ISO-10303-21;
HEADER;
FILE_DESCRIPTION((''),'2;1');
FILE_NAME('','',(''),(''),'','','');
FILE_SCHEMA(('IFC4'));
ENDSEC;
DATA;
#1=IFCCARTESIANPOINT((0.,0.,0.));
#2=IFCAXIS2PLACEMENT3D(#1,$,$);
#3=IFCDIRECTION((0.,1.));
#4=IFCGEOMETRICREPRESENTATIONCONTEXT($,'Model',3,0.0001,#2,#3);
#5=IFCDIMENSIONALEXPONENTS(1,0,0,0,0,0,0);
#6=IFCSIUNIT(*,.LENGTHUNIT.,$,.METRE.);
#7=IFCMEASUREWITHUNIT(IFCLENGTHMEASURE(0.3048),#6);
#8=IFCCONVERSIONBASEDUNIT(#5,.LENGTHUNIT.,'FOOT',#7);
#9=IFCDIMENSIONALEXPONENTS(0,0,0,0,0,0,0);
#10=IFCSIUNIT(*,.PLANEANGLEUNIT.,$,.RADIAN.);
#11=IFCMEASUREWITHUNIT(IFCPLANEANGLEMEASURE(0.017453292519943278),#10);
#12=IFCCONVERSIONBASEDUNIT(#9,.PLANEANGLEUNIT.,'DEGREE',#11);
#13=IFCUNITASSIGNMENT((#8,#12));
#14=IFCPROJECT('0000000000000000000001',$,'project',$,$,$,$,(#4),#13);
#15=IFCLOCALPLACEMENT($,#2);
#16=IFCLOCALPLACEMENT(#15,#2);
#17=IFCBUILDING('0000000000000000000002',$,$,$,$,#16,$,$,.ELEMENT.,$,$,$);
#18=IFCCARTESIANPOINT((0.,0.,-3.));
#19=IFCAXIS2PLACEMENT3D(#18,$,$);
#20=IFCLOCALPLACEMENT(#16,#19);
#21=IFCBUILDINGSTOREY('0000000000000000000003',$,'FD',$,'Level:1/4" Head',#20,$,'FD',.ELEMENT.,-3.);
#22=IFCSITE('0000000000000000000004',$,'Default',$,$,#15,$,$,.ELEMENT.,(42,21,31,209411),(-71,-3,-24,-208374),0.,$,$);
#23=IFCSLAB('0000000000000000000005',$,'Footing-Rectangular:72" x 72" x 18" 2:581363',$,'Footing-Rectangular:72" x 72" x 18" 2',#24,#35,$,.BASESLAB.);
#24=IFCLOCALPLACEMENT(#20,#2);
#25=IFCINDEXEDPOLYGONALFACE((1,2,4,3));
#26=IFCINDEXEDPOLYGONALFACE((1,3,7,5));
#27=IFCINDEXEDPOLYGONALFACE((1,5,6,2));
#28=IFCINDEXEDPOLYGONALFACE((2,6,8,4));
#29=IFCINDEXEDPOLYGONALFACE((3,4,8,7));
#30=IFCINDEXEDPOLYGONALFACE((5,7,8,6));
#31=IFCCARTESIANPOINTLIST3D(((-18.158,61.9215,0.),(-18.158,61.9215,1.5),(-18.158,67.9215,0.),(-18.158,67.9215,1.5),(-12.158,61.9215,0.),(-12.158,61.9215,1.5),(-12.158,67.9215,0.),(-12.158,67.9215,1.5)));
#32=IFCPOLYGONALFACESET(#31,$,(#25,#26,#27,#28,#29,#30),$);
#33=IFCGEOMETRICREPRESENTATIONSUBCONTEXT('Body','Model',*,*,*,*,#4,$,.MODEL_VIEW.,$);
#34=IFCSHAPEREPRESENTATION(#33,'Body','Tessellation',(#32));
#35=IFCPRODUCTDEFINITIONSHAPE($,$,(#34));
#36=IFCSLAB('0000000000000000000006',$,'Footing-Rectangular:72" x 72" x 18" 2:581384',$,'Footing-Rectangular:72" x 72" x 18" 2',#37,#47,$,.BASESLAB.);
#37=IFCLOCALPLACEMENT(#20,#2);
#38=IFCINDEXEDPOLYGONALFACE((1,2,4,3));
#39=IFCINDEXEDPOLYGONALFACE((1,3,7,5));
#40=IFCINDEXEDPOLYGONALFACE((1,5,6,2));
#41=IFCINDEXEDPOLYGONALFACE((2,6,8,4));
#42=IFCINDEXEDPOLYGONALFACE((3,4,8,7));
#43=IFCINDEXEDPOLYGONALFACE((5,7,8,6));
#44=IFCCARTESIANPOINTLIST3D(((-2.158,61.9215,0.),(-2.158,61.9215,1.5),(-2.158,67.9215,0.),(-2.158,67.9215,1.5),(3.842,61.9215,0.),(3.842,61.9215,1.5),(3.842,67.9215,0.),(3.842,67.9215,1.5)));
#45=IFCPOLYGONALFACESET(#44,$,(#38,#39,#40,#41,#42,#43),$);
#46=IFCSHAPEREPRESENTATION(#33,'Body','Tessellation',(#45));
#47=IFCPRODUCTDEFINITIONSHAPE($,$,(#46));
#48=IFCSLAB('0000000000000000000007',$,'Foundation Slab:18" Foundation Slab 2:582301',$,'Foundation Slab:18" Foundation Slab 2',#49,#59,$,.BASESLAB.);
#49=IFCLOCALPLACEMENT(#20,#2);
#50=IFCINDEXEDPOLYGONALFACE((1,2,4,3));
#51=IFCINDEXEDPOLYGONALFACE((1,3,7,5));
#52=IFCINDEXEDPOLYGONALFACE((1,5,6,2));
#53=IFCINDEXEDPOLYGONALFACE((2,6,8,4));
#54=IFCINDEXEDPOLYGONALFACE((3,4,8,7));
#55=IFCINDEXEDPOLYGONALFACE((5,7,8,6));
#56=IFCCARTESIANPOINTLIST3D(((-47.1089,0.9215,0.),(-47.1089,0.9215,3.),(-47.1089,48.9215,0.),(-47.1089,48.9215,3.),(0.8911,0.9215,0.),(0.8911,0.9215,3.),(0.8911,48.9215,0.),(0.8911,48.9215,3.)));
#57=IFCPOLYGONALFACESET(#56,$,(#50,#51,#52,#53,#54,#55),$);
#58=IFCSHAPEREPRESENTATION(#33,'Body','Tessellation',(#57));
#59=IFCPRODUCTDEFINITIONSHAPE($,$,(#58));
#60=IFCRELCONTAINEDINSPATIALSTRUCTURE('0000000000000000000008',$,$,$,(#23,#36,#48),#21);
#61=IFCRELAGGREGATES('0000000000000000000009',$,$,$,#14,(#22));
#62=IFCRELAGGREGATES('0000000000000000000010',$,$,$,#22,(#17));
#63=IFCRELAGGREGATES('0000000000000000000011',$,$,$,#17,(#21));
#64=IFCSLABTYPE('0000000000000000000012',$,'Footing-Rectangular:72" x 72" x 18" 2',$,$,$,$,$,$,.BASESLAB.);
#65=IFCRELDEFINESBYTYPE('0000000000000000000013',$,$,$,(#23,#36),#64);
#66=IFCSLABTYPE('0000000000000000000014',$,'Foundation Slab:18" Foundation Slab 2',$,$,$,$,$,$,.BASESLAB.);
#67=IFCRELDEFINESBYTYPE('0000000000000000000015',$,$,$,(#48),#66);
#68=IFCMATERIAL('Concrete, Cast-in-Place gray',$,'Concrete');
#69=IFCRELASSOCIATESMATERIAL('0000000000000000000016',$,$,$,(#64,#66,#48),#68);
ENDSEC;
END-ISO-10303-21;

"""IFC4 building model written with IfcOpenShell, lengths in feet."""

from ifc_helpers import new_model, entity, si_unit, converted_unit, direction, frame, origin, place, context, subcontext, project, spatial, indexed_curve, outline, extrude, material, type_object, element, save


model = new_model("IFC4")

# Units and contexts
model_context = context("Model", 3, precision=0.0001, world=origin(), true_north=direction((0.0, 1.0)))
body_context = subcontext(model_context, "Body", "Model", "MODEL_VIEW")
ifc_project = project(units=[converted_unit("LENGTHUNIT", "FOOT", entity("IfcLengthMeasure", 0.3048), si_unit("LENGTHUNIT", "METRE"), dimensions=[1, 0, 0, 0, 0, 0, 0]), converted_unit("PLANEANGLEUNIT", "DEGREE", entity("IfcPlaneAngleMeasure", 0.017453292519943278), si_unit("PLANEANGLEUNIT", "RADIAN"), dimensions=[0, 0, 0, 0, 0, 0, 0])], contexts=[model_context])

# Site, building, storey
site_placement = place(None, origin())
site = spatial("IfcSite", under=ifc_project, at=site_placement, Name="Default", CompositionType="ELEMENT", RefLatitude=(42, 21, 31, 209411), RefLongitude=(-71, -3, -24, -208374), RefElevation=0.0)
building_placement = place(site_placement, origin())
building = spatial("IfcBuilding", under=site, at=building_placement, CompositionType="ELEMENT")
storey_placement = place(building_placement, frame((0.0, 0.0, -3.0)))
storey = spatial("IfcBuildingStorey", under=building, at=storey_placement, Name="FD", ObjectType="Level:1/4\" Head", LongName="FD", CompositionType="ELEMENT", Elevation=-3.0)

# Shared definitions
ifc_material = material(Name="Concrete, Cast-in-Place gray", Category="Concrete")

# Slabs
slab_type_1 = type_object("IfcSlabType", Name="Footing-Rectangular:72\" x 72\" x 18\" 2", PredefinedType="BASESLAB", material=ifc_material)
slab_1_placement = place(storey_placement, origin())
element("IfcSlab", 1, at=slab_1_placement, inside=storey, type_object=slab_type_1, Name="Footing-Rectangular:72\" x 72\" x 18\" 2:581363", ObjectType="Footing-Rectangular:72\" x 72\" x 18\" 2", PredefinedType="BASESLAB", context=body_context, shape_type="SweptSolid", body=[
    extrude(outline(indexed_curve([(-3.0, -3.0), (3.0, -3.0), (3.0, 3.0), (-3.0, 3.0), (-3.0, -3.0)], self_intersect=False)), frame((-15.158, 64.9215, 0.0), z_axis=(0.0, 0.0, 1.0), x_axis=(-1.0, 0.0, 0.0)), (0.0, 0.0, 1.0), 1.5),
])
slab_2_placement = place(storey_placement, origin())
element("IfcSlab", 2, at=slab_2_placement, inside=storey, type_object=slab_type_1, Name="Footing-Rectangular:72\" x 72\" x 18\" 2:581384", ObjectType="Footing-Rectangular:72\" x 72\" x 18\" 2", PredefinedType="BASESLAB", context=body_context, shape_type="SweptSolid", body=[
    extrude(outline(indexed_curve([(-3.0, -3.0), (3.0, -3.0), (3.0, 3.0), (-3.0, 3.0), (-3.0, -3.0)], self_intersect=False)), frame((0.842, 64.9215, 0.0), z_axis=(0.0, 0.0, 1.0), x_axis=(-1.0, 0.0, 0.0)), (0.0, 0.0, 1.0), 1.5),
])
slab_type_2 = type_object("IfcSlabType", Name="Foundation Slab:18\" Foundation Slab 2", PredefinedType="BASESLAB", material=ifc_material)
slab_3_placement = place(storey_placement, origin())
element("IfcSlab", 3, at=slab_3_placement, inside=storey, type_object=slab_type_2, material=ifc_material, Name="Foundation Slab:18\" Foundation Slab 2:582301", ObjectType="Foundation Slab:18\" Foundation Slab 2", PredefinedType="BASESLAB", context=body_context, shape_type="SweptSolid", body=[
    extrude(outline(indexed_curve([(-24.0, -24.0), (24.0, -24.0), (24.0, 24.0), (-24.0, 24.0), (-24.0, -24.0)], self_intersect=False)), frame((-23.1089, 24.9215, 3.0), z_axis=(0.0, 0.0, -1.0), x_axis=(0.0, 1.0, 0.0)), (0.0, 0.0, 1.0), 3.0),
])

save(model, "model.ifc")
